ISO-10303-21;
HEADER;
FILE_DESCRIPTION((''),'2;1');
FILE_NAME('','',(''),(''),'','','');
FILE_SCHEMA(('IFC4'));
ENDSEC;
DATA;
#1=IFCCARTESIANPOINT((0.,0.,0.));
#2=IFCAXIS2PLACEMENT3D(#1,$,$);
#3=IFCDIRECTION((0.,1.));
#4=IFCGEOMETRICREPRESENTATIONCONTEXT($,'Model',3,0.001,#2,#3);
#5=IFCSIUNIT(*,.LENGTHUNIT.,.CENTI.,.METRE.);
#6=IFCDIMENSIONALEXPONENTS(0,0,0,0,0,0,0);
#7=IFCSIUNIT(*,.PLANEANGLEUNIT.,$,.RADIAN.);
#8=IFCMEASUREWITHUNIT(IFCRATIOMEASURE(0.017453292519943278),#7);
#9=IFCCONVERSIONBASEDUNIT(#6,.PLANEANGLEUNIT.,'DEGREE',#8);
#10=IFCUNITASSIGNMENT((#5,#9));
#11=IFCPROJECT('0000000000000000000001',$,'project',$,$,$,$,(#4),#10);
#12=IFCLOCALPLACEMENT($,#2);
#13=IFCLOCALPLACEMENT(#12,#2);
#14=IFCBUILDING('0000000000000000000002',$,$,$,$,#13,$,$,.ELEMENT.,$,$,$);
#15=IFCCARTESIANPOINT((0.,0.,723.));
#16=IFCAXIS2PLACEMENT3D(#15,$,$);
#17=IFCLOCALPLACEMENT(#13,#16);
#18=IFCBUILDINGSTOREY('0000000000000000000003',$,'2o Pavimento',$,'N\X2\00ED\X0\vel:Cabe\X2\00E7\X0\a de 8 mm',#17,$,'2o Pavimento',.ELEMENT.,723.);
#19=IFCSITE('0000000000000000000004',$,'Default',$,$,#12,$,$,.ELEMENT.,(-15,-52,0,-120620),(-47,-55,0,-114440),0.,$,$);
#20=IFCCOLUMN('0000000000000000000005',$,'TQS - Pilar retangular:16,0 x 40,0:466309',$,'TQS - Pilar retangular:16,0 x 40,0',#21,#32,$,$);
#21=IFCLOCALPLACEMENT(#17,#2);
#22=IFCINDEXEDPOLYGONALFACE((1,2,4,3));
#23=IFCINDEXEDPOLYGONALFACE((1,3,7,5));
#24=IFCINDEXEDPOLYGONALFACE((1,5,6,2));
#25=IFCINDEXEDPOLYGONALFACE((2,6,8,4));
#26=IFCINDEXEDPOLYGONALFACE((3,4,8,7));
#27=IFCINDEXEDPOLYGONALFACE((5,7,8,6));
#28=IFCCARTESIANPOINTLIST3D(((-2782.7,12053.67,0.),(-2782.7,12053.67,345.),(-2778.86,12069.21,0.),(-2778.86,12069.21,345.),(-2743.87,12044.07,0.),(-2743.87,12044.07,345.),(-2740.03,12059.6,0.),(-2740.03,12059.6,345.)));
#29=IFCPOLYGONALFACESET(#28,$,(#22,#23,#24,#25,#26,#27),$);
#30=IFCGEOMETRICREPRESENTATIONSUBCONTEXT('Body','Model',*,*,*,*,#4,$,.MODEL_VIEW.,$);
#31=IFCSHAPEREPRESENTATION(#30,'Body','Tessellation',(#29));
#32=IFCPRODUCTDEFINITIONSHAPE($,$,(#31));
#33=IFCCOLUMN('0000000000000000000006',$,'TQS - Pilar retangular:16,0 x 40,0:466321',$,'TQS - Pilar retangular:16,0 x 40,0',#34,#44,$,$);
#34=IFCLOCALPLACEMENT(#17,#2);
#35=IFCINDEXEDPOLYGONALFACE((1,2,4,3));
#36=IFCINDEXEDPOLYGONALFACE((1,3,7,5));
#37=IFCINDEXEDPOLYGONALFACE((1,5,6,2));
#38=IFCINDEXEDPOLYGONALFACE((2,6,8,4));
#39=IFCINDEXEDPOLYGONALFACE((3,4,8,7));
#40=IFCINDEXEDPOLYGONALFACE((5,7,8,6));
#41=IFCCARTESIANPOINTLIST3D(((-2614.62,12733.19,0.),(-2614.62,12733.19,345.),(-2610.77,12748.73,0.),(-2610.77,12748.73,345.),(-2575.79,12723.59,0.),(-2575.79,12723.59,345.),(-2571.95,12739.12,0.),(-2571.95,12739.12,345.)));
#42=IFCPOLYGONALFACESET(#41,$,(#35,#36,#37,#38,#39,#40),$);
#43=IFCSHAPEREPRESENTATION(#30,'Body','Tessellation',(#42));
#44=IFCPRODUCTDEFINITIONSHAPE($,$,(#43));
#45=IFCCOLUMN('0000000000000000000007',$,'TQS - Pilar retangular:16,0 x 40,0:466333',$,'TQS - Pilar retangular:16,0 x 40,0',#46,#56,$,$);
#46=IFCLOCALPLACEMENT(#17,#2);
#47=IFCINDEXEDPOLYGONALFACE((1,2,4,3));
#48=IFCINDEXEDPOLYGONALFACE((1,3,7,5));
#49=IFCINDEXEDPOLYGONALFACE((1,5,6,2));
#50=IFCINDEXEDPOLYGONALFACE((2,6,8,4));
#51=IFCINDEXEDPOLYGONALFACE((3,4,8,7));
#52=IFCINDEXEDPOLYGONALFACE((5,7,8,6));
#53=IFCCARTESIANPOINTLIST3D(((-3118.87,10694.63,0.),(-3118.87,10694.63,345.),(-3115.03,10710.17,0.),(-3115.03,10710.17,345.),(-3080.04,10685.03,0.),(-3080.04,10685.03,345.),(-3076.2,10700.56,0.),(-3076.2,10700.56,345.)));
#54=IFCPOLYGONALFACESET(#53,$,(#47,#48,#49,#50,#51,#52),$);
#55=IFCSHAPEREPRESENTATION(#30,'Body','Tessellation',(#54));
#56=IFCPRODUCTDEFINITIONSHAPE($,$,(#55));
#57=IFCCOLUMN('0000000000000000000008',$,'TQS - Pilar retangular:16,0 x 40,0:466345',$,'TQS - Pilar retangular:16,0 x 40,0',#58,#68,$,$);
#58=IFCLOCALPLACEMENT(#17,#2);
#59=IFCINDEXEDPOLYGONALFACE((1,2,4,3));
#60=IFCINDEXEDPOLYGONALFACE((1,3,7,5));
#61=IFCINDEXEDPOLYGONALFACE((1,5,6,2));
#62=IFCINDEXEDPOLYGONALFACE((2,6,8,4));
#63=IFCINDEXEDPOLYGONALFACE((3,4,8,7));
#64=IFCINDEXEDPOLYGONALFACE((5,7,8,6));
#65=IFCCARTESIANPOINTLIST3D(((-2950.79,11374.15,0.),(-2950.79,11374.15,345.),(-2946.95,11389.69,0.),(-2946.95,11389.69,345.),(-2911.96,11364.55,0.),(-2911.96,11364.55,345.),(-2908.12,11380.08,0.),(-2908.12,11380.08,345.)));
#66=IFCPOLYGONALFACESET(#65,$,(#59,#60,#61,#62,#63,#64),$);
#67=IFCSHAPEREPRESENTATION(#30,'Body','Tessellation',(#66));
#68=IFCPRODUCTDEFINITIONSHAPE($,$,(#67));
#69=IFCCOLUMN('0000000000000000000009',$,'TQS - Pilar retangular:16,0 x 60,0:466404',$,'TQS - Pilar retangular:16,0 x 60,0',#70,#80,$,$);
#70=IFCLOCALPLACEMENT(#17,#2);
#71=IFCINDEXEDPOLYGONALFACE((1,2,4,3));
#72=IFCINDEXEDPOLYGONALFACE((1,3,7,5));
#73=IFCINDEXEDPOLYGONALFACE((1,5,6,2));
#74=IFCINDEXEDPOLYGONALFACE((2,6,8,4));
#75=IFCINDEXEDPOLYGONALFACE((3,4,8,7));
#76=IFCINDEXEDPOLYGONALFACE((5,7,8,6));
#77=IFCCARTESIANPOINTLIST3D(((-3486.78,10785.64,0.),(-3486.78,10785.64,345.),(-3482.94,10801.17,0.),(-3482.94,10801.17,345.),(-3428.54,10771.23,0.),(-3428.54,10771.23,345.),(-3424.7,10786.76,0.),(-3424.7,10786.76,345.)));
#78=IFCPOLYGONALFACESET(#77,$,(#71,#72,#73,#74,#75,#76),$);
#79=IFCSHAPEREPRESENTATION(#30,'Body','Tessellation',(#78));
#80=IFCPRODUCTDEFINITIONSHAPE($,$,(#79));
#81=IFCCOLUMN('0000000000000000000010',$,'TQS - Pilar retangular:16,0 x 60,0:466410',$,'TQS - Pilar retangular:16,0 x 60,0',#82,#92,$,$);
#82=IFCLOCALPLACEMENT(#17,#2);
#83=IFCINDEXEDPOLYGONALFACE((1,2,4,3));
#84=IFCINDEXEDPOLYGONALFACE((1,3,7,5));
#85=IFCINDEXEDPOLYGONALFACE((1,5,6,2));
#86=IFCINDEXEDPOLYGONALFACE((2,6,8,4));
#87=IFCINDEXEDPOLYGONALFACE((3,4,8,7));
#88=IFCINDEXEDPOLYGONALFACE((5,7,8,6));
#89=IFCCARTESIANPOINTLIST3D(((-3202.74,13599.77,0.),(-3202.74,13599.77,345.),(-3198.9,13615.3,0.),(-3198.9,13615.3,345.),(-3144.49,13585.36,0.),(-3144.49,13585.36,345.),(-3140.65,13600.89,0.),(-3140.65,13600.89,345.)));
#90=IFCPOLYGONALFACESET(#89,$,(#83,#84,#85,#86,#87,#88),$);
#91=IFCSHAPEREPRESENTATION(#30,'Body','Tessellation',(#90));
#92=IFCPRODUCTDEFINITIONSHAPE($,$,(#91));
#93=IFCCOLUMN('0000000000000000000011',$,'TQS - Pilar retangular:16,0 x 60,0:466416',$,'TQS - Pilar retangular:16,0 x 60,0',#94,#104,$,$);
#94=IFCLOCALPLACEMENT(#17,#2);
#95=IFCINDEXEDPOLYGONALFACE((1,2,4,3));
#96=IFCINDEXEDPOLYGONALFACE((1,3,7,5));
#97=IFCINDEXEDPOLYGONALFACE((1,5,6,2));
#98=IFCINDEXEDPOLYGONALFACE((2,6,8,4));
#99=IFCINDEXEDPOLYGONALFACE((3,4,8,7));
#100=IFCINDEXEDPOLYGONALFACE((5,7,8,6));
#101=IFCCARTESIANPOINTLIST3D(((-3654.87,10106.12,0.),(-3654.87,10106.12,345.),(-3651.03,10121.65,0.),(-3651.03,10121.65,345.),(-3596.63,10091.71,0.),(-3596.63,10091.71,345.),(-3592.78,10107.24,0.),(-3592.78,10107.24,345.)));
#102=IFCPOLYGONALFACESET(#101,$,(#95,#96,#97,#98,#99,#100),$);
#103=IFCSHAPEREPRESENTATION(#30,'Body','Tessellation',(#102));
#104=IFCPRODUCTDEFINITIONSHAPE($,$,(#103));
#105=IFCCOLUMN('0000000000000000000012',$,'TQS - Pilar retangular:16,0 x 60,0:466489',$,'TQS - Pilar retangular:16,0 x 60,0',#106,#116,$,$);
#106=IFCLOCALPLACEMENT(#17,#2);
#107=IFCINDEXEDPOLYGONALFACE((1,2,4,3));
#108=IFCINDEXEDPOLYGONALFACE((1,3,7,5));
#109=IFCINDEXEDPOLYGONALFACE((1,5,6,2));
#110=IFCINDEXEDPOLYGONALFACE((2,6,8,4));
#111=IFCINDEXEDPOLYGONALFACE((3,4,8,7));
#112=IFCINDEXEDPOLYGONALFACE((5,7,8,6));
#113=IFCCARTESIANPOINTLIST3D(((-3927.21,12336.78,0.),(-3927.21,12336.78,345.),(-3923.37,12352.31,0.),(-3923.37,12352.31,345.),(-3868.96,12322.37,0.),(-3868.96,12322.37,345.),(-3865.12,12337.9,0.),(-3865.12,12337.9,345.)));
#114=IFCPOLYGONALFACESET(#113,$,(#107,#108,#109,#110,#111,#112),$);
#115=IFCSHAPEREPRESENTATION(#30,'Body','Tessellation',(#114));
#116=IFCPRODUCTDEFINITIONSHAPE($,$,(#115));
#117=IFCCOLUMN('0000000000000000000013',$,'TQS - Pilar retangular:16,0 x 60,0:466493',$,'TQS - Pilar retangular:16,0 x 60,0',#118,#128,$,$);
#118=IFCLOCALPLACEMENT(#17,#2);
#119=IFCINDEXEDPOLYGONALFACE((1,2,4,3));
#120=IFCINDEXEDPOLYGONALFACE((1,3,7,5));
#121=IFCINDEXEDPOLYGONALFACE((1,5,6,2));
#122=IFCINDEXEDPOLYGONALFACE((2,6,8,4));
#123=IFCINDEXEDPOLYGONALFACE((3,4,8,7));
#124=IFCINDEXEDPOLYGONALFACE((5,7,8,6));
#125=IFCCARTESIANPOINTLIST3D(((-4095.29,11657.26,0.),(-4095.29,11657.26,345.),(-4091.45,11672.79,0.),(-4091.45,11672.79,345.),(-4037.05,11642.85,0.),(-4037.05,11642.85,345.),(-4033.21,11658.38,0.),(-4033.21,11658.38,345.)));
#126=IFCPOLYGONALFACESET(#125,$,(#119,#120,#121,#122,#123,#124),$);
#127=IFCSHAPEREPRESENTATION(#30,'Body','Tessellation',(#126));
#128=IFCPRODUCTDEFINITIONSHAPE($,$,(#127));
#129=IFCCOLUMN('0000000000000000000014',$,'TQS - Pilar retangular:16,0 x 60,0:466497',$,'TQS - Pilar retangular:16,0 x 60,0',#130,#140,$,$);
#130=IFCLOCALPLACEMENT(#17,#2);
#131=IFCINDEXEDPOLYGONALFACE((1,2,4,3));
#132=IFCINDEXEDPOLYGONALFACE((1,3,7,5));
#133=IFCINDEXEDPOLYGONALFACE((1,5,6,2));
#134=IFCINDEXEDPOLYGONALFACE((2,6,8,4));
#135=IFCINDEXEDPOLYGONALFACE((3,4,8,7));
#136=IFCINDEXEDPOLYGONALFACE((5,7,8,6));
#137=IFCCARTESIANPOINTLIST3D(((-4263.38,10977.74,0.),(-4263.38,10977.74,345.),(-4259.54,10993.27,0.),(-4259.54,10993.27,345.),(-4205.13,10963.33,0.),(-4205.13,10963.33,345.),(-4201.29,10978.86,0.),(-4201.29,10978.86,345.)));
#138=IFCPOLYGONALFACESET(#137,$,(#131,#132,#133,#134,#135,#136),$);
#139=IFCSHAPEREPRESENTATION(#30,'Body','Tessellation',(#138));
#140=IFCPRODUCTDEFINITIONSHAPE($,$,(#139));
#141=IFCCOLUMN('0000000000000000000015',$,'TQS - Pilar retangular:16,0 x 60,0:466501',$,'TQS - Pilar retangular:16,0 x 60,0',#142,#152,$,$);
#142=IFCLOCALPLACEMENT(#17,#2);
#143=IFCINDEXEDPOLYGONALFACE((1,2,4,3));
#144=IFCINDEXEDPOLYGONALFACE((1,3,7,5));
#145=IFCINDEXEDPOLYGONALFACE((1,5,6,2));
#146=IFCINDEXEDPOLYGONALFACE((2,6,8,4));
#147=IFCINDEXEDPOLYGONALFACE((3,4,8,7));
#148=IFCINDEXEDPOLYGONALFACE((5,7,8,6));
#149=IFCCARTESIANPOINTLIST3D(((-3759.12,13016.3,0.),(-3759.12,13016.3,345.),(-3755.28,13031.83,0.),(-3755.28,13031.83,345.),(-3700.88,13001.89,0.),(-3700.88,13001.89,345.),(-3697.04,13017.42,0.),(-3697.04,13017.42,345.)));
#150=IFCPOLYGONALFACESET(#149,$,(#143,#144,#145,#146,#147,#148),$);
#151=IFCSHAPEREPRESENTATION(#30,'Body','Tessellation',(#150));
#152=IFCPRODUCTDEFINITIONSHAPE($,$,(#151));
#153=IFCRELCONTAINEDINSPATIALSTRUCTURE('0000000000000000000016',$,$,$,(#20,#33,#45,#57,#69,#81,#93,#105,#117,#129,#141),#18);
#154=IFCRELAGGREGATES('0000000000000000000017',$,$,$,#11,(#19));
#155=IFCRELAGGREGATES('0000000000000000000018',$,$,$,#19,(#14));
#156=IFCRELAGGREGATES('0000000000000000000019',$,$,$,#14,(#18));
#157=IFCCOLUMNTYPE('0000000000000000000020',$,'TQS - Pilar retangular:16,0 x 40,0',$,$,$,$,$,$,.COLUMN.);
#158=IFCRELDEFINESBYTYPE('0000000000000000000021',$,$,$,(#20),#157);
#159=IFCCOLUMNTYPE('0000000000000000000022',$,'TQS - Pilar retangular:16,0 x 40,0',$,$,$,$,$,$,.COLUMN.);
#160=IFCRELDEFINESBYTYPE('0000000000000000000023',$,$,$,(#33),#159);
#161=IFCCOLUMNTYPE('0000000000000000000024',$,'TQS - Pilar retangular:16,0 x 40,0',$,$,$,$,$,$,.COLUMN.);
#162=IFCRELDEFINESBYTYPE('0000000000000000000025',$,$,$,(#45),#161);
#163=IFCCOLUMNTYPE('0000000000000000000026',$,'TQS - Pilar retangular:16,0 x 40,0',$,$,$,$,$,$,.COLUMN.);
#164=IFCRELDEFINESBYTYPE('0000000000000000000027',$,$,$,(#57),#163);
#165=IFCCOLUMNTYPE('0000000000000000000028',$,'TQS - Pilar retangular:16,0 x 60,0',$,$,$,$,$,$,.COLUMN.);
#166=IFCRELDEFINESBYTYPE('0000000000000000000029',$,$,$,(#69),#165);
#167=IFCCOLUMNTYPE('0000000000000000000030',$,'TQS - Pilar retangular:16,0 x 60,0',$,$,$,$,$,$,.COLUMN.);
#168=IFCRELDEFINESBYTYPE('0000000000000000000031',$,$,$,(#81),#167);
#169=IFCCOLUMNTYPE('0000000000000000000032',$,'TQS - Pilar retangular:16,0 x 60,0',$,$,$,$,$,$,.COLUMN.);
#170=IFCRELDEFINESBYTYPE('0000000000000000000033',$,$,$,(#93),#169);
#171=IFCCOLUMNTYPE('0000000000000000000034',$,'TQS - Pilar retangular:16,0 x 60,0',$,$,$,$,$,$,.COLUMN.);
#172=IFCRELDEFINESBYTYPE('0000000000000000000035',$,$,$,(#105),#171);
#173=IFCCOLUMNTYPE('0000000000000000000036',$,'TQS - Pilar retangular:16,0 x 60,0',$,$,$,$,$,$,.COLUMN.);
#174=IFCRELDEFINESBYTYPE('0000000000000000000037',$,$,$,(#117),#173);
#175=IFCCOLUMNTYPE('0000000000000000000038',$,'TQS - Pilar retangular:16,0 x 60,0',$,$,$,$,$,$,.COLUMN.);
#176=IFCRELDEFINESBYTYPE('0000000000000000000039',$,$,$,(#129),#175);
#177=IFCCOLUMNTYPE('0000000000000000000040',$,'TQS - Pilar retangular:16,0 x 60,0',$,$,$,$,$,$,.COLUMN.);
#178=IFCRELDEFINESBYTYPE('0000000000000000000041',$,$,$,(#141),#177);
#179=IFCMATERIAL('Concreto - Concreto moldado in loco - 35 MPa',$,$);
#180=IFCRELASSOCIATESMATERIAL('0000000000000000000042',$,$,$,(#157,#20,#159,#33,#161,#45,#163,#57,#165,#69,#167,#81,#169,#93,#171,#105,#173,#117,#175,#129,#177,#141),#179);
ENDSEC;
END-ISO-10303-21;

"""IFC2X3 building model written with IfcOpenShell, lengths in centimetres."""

from ifc_helpers import new_model, entity, si_unit, converted_unit, direction, frame, frame_2d, origin, origin_2d_with_axis, place, context, subcontext, project, spatial, rectangle, extrude, source, transform, mapped, material, type_object, type_shapes, element, save


model = new_model("IFC2X3")

# Units and contexts
model_context = context("Model", 3, precision=0.001, world=origin(), true_north=direction((0.0, 1.0)))
body_context = subcontext(model_context, "Body", "Model", "MODEL_VIEW")
ifc_project = project(units=[si_unit("LENGTHUNIT", "METRE", prefix="CENTI"), converted_unit("PLANEANGLEUNIT", "DEGREE", entity("IfcRatioMeasure", 0.017453292519943278), si_unit("PLANEANGLEUNIT", "RADIAN"), dimensions=[0, 0, 0, 0, 0, 0, 0])], contexts=[model_context])

# Site, building, storey
site_placement = place(None, origin())
site = spatial("IfcSite", under=ifc_project, at=site_placement, Name="Default", CompositionType="ELEMENT", RefLatitude=(-15, -52, 0, -120620), RefLongitude=(-47, -55, 0, -114440), RefElevation=0.0)
building_placement = place(site_placement, origin())
building = spatial("IfcBuilding", under=site, at=building_placement, CompositionType="ELEMENT")
storey_placement = place(building_placement, frame((0.0, 0.0, 723.0)))
storey = spatial("IfcBuildingStorey", under=building, at=storey_placement, Name="2o Pavimento", ObjectType="Nível:Cabeça de 8 mm", LongName="2o Pavimento", CompositionType="ELEMENT", Elevation=723.0)

# Columns
ifc_material = material(Name="Concreto - Concreto moldado in loco - 35 MPa")
column_type_1 = type_object("IfcColumnType", Name="TQS - Pilar retangular:16,0 x 40,0", PredefinedType="COLUMN", material=ifc_material)
shared_shape_1 = source(origin(), body_context, "Body", "SweptSolid", [
    extrude(rectangle(XDim=40.0, YDim=16.0, at=origin_2d_with_axis()), frame((-2761.37, 12056.64, 723.0), z_axis=(0.0, 0.0, 1.0), x_axis=(-0.970743, 0.240122, 0.0)), (0.0, 0.0, 1.0), 345.0),
])
type_shapes(column_type_1, [shared_shape_1])
column_1_placement = place(storey_placement, frame((0.0, 0.0, -723.0)))
element("IfcColumn", 1, at=column_1_placement, inside=storey, type_object=column_type_1, material=ifc_material, Name="TQS - Pilar retangular:16,0 x 40,0:466309", ObjectType="TQS - Pilar retangular:16,0 x 40,0", context=body_context, shape_type="MappedRepresentation", body=[
    mapped(shared_shape_1, transform((0.0, 0.0, 0.0), scale=1.0)),
])
column_type_2 = type_object("IfcColumnType", Name="TQS - Pilar retangular:16,0 x 40,0", PredefinedType="COLUMN", material=ifc_material)
shared_shape_2 = source(origin(), body_context, "Body", "SweptSolid", [
    extrude(rectangle(XDim=40.0, YDim=16.0, at=origin_2d_with_axis()), frame((-2593.28, 12736.16, 723.0), z_axis=(0.0, 0.0, 1.0), x_axis=(-0.970743, 0.240122, 0.0)), (0.0, 0.0, 1.0), 345.0),
])
type_shapes(column_type_2, [shared_shape_2])
column_2_placement = place(storey_placement, frame((0.0, 0.0, -723.0)))
element("IfcColumn", 2, at=column_2_placement, inside=storey, type_object=column_type_2, material=ifc_material, Name="TQS - Pilar retangular:16,0 x 40,0:466321", ObjectType="TQS - Pilar retangular:16,0 x 40,0", context=body_context, shape_type="MappedRepresentation", body=[
    mapped(shared_shape_2, transform((0.0, 0.0, 0.0), scale=1.0)),
])
column_type_3 = type_object("IfcColumnType", Name="TQS - Pilar retangular:16,0 x 40,0", PredefinedType="COLUMN", material=ifc_material)
shared_shape_3 = source(origin(), body_context, "Body", "SweptSolid", [
    extrude(rectangle(XDim=40.0, YDim=16.0, at=origin_2d_with_axis()), frame((-3097.54, 10697.6, 723.0), z_axis=(0.0, 0.0, 1.0), x_axis=(-0.970743, 0.240122, 0.0)), (0.0, 0.0, 1.0), 345.0),
])
type_shapes(column_type_3, [shared_shape_3])
column_3_placement = place(storey_placement, frame((0.0, 0.0, -723.0)))
element("IfcColumn", 3, at=column_3_placement, inside=storey, type_object=column_type_3, material=ifc_material, Name="TQS - Pilar retangular:16,0 x 40,0:466333", ObjectType="TQS - Pilar retangular:16,0 x 40,0", context=body_context, shape_type="MappedRepresentation", body=[
    mapped(shared_shape_3, transform((0.0, 0.0, 0.0), scale=1.0)),
])
column_type_4 = type_object("IfcColumnType", Name="TQS - Pilar retangular:16,0 x 40,0", PredefinedType="COLUMN", material=ifc_material)
shared_shape_4 = source(origin(), body_context, "Body", "SweptSolid", [
    extrude(rectangle(XDim=40.0, YDim=16.0, at=origin_2d_with_axis()), frame((-2929.45, 11377.12, 723.0), z_axis=(0.0, 0.0, 1.0), x_axis=(-0.970743, 0.240122, 0.0)), (0.0, 0.0, 1.0), 345.0),
])
type_shapes(column_type_4, [shared_shape_4])
column_4_placement = place(storey_placement, frame((0.0, 0.0, -723.0)))
element("IfcColumn", 4, at=column_4_placement, inside=storey, type_object=column_type_4, material=ifc_material, Name="TQS - Pilar retangular:16,0 x 40,0:466345", ObjectType="TQS - Pilar retangular:16,0 x 40,0", context=body_context, shape_type="MappedRepresentation", body=[
    mapped(shared_shape_4, transform((0.0, 0.0, 0.0), scale=1.0)),
])
column_type_5 = type_object("IfcColumnType", Name="TQS - Pilar retangular:16,0 x 60,0", PredefinedType="COLUMN", material=ifc_material)
shared_shape_5 = source(origin(), body_context, "Body", "SweptSolid", [
    extrude(rectangle(XDim=60.0, YDim=16.0, at=origin_2d_with_axis()), frame((-3455.74, 10786.2, 723.0), z_axis=(0.0, 0.0, 1.0), x_axis=(-0.970743, 0.240122, 0.0)), (0.0, 0.0, 1.0), 345.0),
])
type_shapes(column_type_5, [shared_shape_5])
column_5_placement = place(storey_placement, frame((0.0, 0.0, -723.0)))
element("IfcColumn", 5, at=column_5_placement, inside=storey, type_object=column_type_5, material=ifc_material, Name="TQS - Pilar retangular:16,0 x 60,0:466404", ObjectType="TQS - Pilar retangular:16,0 x 60,0", context=body_context, shape_type="MappedRepresentation", body=[
    mapped(shared_shape_5, transform((0.0, 0.0, 0.0), scale=1.0)),
])
column_type_6 = type_object("IfcColumnType", Name="TQS - Pilar retangular:16,0 x 60,0", PredefinedType="COLUMN", material=ifc_material)
shared_shape_6 = source(origin(), body_context, "Body", "SweptSolid", [
    extrude(rectangle(XDim=60.0, YDim=16.0, at=origin_2d_with_axis()), frame((-3171.7, 13600.33, 723.0), z_axis=(0.0, 0.0, 1.0), x_axis=(-0.970743, 0.240122, 0.0)), (0.0, 0.0, 1.0), 345.0),
])
type_shapes(column_type_6, [shared_shape_6])
column_6_placement = place(storey_placement, frame((0.0, 0.0, -723.0)))
element("IfcColumn", 6, at=column_6_placement, inside=storey, type_object=column_type_6, material=ifc_material, Name="TQS - Pilar retangular:16,0 x 60,0:466410", ObjectType="TQS - Pilar retangular:16,0 x 60,0", context=body_context, shape_type="MappedRepresentation", body=[
    mapped(shared_shape_6, transform((0.0, 0.0, 0.0), scale=1.0)),
])
column_type_7 = type_object("IfcColumnType", Name="TQS - Pilar retangular:16,0 x 60,0", PredefinedType="COLUMN", material=ifc_material)
shared_shape_7 = source(origin(), body_context, "Body", "SweptSolid", [
    extrude(rectangle(XDim=60.0, YDim=16.0, at=origin_2d_with_axis()), frame((-3623.83, 10106.68, 723.0), z_axis=(0.0, 0.0, 1.0), x_axis=(-0.970743, 0.240122, 0.0)), (0.0, 0.0, 1.0), 345.0),
])
type_shapes(column_type_7, [shared_shape_7])
column_7_placement = place(storey_placement, frame((0.0, 0.0, -723.0)))
element("IfcColumn", 7, at=column_7_placement, inside=storey, type_object=column_type_7, material=ifc_material, Name="TQS - Pilar retangular:16,0 x 60,0:466416", ObjectType="TQS - Pilar retangular:16,0 x 60,0", context=body_context, shape_type="MappedRepresentation", body=[
    mapped(shared_shape_7, transform((0.0, 0.0, 0.0), scale=1.0)),
])
column_type_8 = type_object("IfcColumnType", Name="TQS - Pilar retangular:16,0 x 60,0", PredefinedType="COLUMN", material=ifc_material)
shared_shape_8 = source(origin(), body_context, "Body", "SweptSolid", [
    extrude(rectangle(XDim=60.0, YDim=16.0, at=frame_2d((0.0, 0.0), x_axis=(1.0, 0.0))), frame((-3896.16, 12337.34, 723.0), z_axis=(0.0, 0.0, 1.0), x_axis=(-0.970743, 0.240122, 0.0)), (0.0, 0.0, 1.0), 345.0),
])
type_shapes(column_type_8, [shared_shape_8])
column_8_placement = place(storey_placement, frame((0.0, 0.0, -723.0)))
element("IfcColumn", 8, at=column_8_placement, inside=storey, type_object=column_type_8, material=ifc_material, Name="TQS - Pilar retangular:16,0 x 60,0:466489", ObjectType="TQS - Pilar retangular:16,0 x 60,0", context=body_context, shape_type="MappedRepresentation", body=[
    mapped(shared_shape_8, transform((0.0, 0.0, 0.0), scale=1.0)),
])
column_type_9 = type_object("IfcColumnType", Name="TQS - Pilar retangular:16,0 x 60,0", PredefinedType="COLUMN", material=ifc_material)
shared_shape_9 = source(origin(), body_context, "Body", "SweptSolid", [
    extrude(rectangle(XDim=60.0, YDim=16.0, at=origin_2d_with_axis()), frame((-4064.25, 11657.82, 723.0), z_axis=(0.0, 0.0, 1.0), x_axis=(-0.970743, 0.240122, 0.0)), (0.0, 0.0, 1.0), 345.0),
])
type_shapes(column_type_9, [shared_shape_9])
column_9_placement = place(storey_placement, frame((0.0, 0.0, -723.0)))
element("IfcColumn", 9, at=column_9_placement, inside=storey, type_object=column_type_9, material=ifc_material, Name="TQS - Pilar retangular:16,0 x 60,0:466493", ObjectType="TQS - Pilar retangular:16,0 x 60,0", context=body_context, shape_type="MappedRepresentation", body=[
    mapped(shared_shape_9, transform((0.0, 0.0, 0.0), scale=1.0)),
])
column_type_10 = type_object("IfcColumnType", Name="TQS - Pilar retangular:16,0 x 60,0", PredefinedType="COLUMN", material=ifc_material)
shared_shape_10 = source(origin(), body_context, "Body", "SweptSolid", [
    extrude(rectangle(XDim=60.0, YDim=16.0, at=origin_2d_with_axis()), frame((-4232.34, 10978.3, 723.0), z_axis=(0.0, 0.0, 1.0), x_axis=(-0.970743, 0.240122, 0.0)), (0.0, 0.0, 1.0), 345.0),
])
type_shapes(column_type_10, [shared_shape_10])
column_10_placement = place(storey_placement, frame((0.0, 0.0, -723.0)))
element("IfcColumn", 10, at=column_10_placement, inside=storey, type_object=column_type_10, material=ifc_material, Name="TQS - Pilar retangular:16,0 x 60,0:466497", ObjectType="TQS - Pilar retangular:16,0 x 60,0", context=body_context, shape_type="MappedRepresentation", body=[
    mapped(shared_shape_10, transform((0.0, 0.0, 0.0), scale=1.0)),
])
column_type_11 = type_object("IfcColumnType", Name="TQS - Pilar retangular:16,0 x 60,0", PredefinedType="COLUMN", material=ifc_material)
shared_shape_11 = source(origin(), body_context, "Body", "SweptSolid", [
    extrude(rectangle(XDim=60.0, YDim=16.0, at=origin_2d_with_axis()), frame((-3728.08, 13016.86, 723.0), z_axis=(0.0, 0.0, 1.0), x_axis=(-0.970743, 0.240122, 0.0)), (0.0, 0.0, 1.0), 345.0),
])
type_shapes(column_type_11, [shared_shape_11])
column_11_placement = place(storey_placement, frame((0.0, 0.0, -723.0)))
element("IfcColumn", 11, at=column_11_placement, inside=storey, type_object=column_type_11, material=ifc_material, Name="TQS - Pilar retangular:16,0 x 60,0:466501", ObjectType="TQS - Pilar retangular:16,0 x 60,0", context=body_context, shape_type="MappedRepresentation", body=[
    mapped(shared_shape_11, transform((0.0, 0.0, 0.0), scale=1.0)),
])

save(model, "model.ifc")
